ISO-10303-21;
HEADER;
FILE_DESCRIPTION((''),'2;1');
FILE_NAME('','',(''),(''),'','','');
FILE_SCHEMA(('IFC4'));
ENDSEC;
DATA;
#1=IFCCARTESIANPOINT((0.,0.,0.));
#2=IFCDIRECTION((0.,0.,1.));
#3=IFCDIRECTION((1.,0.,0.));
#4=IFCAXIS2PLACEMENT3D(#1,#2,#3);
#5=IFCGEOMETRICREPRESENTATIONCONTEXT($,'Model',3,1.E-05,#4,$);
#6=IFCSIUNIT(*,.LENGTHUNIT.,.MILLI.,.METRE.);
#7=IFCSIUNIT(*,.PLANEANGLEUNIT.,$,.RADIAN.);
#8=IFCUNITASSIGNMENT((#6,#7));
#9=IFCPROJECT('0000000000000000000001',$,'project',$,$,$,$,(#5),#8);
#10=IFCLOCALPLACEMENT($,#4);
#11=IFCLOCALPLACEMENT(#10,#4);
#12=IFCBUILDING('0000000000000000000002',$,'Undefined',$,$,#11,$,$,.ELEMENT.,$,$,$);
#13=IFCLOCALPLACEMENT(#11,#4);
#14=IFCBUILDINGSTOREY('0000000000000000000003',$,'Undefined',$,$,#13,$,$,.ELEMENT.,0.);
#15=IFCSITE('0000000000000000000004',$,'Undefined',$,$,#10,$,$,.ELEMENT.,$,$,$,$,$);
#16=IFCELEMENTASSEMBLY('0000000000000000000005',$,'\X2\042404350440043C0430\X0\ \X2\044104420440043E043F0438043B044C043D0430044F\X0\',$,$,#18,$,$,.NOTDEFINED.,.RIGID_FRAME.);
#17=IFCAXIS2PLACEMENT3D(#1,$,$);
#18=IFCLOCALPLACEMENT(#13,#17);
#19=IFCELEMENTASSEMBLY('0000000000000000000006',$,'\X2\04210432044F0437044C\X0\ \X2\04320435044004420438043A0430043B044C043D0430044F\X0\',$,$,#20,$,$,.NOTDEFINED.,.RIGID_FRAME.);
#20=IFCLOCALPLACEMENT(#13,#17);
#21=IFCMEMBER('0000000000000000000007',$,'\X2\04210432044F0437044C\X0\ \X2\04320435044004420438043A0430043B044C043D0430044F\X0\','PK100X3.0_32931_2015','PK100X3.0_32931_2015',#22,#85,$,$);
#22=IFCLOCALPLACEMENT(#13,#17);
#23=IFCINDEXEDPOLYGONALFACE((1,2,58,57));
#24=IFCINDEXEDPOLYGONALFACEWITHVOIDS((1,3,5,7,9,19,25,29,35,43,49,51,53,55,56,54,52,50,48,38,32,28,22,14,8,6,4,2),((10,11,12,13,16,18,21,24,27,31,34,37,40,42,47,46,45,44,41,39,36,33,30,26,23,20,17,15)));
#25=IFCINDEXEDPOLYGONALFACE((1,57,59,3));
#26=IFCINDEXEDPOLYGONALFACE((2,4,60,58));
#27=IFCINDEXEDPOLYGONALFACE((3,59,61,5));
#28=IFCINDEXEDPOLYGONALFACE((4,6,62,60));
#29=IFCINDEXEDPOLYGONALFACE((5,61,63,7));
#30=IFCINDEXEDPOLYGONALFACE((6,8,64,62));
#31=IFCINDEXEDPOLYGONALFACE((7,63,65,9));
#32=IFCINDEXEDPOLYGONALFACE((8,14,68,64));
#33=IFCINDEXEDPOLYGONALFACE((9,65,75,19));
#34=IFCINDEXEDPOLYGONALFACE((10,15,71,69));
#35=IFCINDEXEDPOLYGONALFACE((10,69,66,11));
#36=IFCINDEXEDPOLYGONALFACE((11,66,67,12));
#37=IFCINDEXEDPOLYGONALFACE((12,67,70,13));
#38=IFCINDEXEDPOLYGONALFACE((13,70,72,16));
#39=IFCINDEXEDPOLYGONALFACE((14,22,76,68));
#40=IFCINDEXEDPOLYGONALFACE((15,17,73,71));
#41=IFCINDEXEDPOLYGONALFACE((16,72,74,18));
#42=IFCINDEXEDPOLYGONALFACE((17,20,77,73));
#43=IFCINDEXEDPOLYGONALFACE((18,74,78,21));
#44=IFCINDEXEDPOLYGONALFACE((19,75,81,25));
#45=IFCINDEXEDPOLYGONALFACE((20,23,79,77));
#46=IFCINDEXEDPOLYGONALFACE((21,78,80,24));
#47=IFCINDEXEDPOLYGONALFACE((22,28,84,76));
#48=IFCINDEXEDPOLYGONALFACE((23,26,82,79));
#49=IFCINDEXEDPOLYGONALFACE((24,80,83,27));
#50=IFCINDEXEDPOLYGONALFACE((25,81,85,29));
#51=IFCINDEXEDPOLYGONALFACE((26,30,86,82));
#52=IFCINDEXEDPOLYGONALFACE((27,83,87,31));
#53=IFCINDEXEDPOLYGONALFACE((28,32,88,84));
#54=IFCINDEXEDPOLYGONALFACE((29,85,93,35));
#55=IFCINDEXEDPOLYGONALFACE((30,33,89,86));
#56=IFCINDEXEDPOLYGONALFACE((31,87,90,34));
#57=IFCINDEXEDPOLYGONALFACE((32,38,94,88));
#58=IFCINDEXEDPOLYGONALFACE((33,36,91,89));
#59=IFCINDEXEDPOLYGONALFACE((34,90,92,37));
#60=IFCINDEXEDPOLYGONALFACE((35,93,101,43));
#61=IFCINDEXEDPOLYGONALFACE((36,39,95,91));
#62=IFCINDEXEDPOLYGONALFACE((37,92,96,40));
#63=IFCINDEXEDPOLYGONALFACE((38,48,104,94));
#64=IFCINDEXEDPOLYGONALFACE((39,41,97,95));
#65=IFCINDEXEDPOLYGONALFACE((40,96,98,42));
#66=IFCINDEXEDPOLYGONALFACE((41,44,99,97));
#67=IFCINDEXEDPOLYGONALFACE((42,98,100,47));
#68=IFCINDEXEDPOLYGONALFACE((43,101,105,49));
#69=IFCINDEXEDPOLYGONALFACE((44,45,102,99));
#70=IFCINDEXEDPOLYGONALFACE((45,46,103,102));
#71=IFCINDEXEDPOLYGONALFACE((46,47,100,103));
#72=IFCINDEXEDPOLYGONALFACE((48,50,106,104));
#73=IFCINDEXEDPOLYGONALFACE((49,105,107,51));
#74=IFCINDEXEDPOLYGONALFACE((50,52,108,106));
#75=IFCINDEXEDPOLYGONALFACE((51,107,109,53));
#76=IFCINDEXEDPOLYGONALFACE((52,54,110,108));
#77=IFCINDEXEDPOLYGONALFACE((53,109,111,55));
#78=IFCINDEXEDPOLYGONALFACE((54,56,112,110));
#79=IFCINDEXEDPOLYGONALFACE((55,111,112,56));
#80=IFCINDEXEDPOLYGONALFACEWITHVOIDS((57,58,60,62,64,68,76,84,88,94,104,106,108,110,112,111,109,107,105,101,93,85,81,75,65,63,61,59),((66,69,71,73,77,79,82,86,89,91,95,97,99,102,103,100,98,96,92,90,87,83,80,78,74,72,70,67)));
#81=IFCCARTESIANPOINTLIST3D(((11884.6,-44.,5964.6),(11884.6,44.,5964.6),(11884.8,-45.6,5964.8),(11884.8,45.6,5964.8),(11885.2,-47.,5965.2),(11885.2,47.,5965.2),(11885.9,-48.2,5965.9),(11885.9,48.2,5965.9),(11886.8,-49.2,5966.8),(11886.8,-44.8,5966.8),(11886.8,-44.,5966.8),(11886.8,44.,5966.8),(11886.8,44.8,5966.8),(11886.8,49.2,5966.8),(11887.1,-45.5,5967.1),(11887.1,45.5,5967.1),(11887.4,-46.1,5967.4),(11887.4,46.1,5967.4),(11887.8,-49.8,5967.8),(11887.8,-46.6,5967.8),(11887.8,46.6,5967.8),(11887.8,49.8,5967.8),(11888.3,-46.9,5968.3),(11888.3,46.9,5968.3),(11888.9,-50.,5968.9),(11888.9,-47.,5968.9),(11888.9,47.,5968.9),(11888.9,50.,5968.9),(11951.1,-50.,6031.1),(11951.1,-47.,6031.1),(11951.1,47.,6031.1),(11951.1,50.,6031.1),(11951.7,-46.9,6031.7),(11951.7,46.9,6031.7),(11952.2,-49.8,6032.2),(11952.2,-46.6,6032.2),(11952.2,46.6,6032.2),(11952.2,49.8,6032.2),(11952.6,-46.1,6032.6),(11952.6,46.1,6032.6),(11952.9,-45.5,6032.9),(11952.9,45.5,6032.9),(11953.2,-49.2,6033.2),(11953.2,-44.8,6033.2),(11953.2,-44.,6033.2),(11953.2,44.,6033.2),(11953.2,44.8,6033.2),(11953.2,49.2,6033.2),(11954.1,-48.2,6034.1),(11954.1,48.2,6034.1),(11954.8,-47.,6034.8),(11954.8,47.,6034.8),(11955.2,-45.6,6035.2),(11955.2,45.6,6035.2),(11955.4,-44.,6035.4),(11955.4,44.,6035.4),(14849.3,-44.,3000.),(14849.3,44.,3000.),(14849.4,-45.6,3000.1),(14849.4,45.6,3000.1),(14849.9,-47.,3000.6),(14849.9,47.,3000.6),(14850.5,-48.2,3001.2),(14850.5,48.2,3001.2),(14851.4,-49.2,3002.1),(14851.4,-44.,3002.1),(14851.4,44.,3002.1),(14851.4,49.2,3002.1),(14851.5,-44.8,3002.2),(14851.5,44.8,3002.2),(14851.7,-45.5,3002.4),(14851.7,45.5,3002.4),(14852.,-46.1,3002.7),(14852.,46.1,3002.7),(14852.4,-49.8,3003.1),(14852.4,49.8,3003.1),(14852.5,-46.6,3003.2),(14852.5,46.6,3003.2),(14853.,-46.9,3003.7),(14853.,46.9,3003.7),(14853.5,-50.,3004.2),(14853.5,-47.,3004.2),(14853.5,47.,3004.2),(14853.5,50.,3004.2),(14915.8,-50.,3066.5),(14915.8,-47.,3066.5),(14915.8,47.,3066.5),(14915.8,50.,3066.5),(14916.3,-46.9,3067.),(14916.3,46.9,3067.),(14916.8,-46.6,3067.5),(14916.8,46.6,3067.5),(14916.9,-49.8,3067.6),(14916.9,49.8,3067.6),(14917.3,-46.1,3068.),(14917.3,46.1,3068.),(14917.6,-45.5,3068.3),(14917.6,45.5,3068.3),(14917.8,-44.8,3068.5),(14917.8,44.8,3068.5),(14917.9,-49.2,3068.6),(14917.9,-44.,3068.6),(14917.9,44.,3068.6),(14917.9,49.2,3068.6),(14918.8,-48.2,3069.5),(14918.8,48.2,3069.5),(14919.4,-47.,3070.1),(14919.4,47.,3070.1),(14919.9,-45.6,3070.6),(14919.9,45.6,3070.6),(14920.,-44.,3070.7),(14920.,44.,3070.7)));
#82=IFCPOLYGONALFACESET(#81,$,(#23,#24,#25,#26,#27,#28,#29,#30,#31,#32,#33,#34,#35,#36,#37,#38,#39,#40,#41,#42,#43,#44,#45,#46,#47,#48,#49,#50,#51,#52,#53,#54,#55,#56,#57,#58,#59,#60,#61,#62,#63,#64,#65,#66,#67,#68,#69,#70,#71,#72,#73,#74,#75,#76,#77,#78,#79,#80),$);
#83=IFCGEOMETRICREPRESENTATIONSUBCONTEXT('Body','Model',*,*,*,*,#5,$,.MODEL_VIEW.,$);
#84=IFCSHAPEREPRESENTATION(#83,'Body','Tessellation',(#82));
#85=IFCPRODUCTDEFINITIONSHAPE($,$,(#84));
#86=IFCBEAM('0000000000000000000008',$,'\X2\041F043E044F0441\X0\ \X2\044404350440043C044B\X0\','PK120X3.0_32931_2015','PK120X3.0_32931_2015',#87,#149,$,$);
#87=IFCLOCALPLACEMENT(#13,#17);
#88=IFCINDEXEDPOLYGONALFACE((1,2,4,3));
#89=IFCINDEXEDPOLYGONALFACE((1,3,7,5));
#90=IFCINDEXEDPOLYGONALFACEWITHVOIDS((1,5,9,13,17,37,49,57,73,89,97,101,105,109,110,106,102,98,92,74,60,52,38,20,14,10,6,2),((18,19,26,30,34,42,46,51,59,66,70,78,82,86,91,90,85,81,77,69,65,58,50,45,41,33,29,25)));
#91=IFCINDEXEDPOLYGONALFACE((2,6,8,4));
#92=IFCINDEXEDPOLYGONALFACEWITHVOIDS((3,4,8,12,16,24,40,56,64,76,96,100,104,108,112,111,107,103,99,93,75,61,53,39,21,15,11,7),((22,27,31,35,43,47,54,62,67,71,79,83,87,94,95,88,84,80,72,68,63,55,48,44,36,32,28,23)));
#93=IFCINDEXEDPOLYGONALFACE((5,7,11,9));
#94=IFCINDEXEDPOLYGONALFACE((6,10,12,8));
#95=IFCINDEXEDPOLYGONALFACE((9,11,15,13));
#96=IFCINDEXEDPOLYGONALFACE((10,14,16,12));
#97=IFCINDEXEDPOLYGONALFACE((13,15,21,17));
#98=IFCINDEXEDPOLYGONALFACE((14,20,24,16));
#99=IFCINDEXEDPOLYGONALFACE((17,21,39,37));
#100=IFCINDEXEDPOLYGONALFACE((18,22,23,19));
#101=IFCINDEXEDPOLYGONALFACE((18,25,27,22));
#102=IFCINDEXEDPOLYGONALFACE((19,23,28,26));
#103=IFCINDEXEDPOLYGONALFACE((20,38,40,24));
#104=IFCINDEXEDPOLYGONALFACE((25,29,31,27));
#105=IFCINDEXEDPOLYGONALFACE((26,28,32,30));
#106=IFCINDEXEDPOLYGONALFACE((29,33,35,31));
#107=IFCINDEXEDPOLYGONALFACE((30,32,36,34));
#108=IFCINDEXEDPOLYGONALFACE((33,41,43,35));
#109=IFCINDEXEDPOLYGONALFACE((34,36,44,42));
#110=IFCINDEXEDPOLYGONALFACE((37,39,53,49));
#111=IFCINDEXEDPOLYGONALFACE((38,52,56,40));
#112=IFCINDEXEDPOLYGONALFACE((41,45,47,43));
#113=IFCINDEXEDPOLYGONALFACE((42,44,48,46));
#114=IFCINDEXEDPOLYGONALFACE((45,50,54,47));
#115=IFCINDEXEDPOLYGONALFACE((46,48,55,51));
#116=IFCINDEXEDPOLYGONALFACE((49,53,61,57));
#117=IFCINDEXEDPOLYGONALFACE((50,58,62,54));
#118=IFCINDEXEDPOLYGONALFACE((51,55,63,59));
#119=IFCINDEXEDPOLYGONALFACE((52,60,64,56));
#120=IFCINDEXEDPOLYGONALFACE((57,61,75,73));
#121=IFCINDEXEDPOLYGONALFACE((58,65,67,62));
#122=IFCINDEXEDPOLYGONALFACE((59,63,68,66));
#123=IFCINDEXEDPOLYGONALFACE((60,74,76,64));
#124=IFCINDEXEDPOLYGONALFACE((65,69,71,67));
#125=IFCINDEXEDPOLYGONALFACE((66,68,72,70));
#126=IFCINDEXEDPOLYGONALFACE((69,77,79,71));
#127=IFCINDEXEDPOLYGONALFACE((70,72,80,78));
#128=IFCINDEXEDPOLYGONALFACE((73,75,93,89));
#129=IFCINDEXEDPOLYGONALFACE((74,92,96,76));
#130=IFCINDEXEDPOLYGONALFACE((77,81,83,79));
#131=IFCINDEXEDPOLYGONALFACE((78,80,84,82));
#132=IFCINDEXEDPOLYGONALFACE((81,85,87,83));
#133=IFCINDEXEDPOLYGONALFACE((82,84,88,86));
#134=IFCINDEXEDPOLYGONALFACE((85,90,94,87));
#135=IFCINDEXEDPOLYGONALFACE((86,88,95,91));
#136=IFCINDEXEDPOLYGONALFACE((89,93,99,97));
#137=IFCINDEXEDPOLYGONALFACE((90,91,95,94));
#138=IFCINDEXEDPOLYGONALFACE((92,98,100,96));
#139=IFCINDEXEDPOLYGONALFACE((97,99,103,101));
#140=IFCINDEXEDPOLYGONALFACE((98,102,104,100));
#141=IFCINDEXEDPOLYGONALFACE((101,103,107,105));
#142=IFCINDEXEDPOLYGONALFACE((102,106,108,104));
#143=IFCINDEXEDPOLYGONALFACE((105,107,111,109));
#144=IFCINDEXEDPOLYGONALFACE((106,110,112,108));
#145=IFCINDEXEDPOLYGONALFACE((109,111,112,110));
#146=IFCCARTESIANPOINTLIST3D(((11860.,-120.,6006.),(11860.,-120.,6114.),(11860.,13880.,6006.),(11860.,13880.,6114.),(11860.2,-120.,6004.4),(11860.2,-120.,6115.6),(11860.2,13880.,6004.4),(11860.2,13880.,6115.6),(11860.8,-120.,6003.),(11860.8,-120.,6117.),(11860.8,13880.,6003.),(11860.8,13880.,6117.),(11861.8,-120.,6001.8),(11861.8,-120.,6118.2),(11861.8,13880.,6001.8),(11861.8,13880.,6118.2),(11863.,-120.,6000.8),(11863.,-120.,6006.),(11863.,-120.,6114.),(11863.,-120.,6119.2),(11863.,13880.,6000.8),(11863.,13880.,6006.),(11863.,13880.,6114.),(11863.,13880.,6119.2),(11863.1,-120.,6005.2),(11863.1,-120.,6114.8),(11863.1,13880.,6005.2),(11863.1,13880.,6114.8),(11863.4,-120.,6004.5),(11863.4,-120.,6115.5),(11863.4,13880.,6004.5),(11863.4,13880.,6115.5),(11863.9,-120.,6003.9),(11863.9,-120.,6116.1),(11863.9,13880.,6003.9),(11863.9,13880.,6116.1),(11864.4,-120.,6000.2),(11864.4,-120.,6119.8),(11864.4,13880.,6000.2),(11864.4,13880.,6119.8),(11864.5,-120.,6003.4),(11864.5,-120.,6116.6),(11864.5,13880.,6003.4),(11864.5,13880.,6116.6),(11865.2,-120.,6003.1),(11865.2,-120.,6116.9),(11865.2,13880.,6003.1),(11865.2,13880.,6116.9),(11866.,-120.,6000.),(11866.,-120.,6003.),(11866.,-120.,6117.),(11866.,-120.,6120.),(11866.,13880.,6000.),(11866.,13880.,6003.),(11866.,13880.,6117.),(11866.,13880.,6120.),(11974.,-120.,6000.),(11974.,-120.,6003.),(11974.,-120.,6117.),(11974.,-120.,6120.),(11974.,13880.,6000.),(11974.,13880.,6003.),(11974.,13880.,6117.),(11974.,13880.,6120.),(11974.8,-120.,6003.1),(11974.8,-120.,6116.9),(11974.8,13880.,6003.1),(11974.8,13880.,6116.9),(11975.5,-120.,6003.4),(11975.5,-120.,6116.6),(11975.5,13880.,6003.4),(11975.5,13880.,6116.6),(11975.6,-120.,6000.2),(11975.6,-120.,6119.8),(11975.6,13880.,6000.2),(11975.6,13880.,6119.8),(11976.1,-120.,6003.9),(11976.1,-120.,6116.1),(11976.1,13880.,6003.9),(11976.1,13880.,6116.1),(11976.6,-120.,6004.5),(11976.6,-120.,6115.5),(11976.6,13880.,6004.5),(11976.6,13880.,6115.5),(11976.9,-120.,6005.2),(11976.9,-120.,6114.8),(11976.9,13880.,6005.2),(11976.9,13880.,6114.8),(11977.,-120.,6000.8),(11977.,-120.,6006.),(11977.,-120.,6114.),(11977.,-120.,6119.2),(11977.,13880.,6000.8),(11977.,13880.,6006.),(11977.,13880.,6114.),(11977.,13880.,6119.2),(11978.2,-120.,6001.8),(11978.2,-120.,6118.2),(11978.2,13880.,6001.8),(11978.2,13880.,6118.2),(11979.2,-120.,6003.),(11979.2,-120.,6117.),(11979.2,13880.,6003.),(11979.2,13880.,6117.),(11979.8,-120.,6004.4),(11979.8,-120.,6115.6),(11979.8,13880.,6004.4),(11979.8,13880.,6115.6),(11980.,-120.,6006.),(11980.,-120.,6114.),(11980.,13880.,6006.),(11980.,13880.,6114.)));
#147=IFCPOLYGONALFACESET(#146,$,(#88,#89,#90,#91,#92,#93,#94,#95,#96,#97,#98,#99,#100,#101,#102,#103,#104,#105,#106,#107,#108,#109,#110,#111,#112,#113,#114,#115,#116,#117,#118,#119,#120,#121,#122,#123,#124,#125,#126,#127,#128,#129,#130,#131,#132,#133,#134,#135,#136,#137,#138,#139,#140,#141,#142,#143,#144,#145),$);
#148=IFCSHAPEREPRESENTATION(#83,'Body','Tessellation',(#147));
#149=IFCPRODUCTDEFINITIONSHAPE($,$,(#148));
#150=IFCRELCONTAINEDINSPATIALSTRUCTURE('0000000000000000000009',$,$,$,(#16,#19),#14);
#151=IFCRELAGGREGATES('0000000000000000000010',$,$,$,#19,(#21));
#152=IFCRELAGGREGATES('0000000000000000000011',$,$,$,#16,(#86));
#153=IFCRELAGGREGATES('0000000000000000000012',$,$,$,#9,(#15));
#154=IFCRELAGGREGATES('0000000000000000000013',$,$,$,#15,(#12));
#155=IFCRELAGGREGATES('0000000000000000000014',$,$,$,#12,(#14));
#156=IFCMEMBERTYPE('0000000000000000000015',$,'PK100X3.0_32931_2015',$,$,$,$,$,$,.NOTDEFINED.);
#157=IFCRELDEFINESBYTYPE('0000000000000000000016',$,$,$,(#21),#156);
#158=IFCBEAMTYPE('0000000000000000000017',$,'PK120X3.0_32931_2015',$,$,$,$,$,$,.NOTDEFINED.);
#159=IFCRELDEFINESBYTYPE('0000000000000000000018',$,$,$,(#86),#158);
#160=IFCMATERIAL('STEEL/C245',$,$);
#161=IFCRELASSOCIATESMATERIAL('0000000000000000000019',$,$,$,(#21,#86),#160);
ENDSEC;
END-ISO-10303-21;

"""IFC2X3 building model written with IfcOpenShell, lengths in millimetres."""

from ifc_helpers import new_model, si_unit, frame, origin_with_axes, origin_2d_with_axis, place, context, subcontext, project, spatial, hollow_rectangle, extrude, clip, halfspace, material, type_object, element, aggregate, save


model = new_model("IFC2X3")

# Units and contexts
model_context = context("Model", 3, precision=1e-05, world=origin_with_axes())
body_context = subcontext(model_context, "Body", "Model", "MODEL_VIEW")
ifc_project = project(units=[si_unit("LENGTHUNIT", "METRE", prefix="MILLI"), si_unit("PLANEANGLEUNIT", "RADIAN")], contexts=[model_context])

# Site, building, storey
site_placement = place(None, origin_with_axes())
site = spatial("IfcSite", under=ifc_project, at=site_placement, Name="Undefined", CompositionType="ELEMENT")
building_placement = place(site_placement, origin_with_axes())
building = spatial("IfcBuilding", under=site, at=building_placement, Name="Undefined", CompositionType="ELEMENT")
storey_placement = place(building_placement, origin_with_axes())
storey = spatial("IfcBuildingStorey", under=building, at=storey_placement, Name="Undefined", CompositionType="ELEMENT", Elevation=0.0)

# Shared definitions
ifc_material = material(Name="STEEL/C245")

# Element assembly
assembly_1_placement = place(storey_placement, origin_with_axes())
assembly_1 = element("IfcElementAssembly", 1, at=assembly_1_placement, inside=storey, Name="Ферма стропильная", AssemblyPlace="NOTDEFINED", PredefinedType="RIGID_FRAME")

# Element assembly, member
assembly_2_placement = place(storey_placement, origin_with_axes())
assembly_2 = element("IfcElementAssembly", 2, at=assembly_2_placement, inside=storey, Name="Связь вертикальная", AssemblyPlace="NOTDEFINED", PredefinedType="RIGID_FRAME")
member_type_1 = type_object("IfcMemberType", Name="PK100X3.0_32931_2015", PredefinedType="NOTDEFINED")
member_1_placement = place(assembly_2_placement, frame((14920.0, 0.0, 3000.0), z_axis=(0.707107, 0.0, 0.707107), x_axis=(-0.707107, 0.0, 0.707107)))
member_1 = element("IfcMember", 3, at=member_1_placement, type_object=member_type_1, material=ifc_material, Name="Связь вертикальная", Description="PK100X3.0_32931_2015", ObjectType="PK100X3.0_32931_2015", context=body_context, shape_type="Clipping", body=[
    clip(extrude(hollow_rectangle(XDim=100.0, YDim=100.0, WallThickness=3.0, InnerFilletRadius=3.0, OuterFilletRadius=6.0, at=origin_2d_with_axis()), frame((4242.6, 0.0, 0.0), z_axis=(-1.0, 0.0, 0.0), x_axis=(0.0, -1.0, 0.0)), (0.0, 0.0, 1.0), 4293.6), halfspace(frame((50.0, 0.0, -130.4), z_axis=(-1.0, 0.0, 0.0), x_axis=(0.0, 1.0, 0.0)), False)),
])
aggregate(assembly_2, [member_1])

# Beam
beam_type_1 = type_object("IfcBeamType", Name="PK120X3.0_32931_2015", PredefinedType="NOTDEFINED")
beam_1_placement = place(assembly_1_placement, frame((11920.0, -120.0, 6060.0), z_axis=(0.0, 0.0, 1.0), x_axis=(0.0, 1.0, 0.0)))
beam_1 = element("IfcBeam", 4, at=beam_1_placement, type_object=beam_type_1, material=ifc_material, Name="Пояс фермы", Description="PK120X3.0_32931_2015", ObjectType="PK120X3.0_32931_2015", context=body_context, shape_type="SweptSolid", body=[
    extrude(hollow_rectangle(XDim=120.0, YDim=120.0, WallThickness=3.0, InnerFilletRadius=3.0, OuterFilletRadius=6.0, at=origin_2d_with_axis()), frame((14000.0, 0.0, 0.0), z_axis=(-1.0, 0.0, 0.0), x_axis=(0.0, -1.0, 0.0)), (0.0, 0.0, 1.0), 14000.0),
])
aggregate(assembly_1, [beam_1])

save(model, "model.ifc")
